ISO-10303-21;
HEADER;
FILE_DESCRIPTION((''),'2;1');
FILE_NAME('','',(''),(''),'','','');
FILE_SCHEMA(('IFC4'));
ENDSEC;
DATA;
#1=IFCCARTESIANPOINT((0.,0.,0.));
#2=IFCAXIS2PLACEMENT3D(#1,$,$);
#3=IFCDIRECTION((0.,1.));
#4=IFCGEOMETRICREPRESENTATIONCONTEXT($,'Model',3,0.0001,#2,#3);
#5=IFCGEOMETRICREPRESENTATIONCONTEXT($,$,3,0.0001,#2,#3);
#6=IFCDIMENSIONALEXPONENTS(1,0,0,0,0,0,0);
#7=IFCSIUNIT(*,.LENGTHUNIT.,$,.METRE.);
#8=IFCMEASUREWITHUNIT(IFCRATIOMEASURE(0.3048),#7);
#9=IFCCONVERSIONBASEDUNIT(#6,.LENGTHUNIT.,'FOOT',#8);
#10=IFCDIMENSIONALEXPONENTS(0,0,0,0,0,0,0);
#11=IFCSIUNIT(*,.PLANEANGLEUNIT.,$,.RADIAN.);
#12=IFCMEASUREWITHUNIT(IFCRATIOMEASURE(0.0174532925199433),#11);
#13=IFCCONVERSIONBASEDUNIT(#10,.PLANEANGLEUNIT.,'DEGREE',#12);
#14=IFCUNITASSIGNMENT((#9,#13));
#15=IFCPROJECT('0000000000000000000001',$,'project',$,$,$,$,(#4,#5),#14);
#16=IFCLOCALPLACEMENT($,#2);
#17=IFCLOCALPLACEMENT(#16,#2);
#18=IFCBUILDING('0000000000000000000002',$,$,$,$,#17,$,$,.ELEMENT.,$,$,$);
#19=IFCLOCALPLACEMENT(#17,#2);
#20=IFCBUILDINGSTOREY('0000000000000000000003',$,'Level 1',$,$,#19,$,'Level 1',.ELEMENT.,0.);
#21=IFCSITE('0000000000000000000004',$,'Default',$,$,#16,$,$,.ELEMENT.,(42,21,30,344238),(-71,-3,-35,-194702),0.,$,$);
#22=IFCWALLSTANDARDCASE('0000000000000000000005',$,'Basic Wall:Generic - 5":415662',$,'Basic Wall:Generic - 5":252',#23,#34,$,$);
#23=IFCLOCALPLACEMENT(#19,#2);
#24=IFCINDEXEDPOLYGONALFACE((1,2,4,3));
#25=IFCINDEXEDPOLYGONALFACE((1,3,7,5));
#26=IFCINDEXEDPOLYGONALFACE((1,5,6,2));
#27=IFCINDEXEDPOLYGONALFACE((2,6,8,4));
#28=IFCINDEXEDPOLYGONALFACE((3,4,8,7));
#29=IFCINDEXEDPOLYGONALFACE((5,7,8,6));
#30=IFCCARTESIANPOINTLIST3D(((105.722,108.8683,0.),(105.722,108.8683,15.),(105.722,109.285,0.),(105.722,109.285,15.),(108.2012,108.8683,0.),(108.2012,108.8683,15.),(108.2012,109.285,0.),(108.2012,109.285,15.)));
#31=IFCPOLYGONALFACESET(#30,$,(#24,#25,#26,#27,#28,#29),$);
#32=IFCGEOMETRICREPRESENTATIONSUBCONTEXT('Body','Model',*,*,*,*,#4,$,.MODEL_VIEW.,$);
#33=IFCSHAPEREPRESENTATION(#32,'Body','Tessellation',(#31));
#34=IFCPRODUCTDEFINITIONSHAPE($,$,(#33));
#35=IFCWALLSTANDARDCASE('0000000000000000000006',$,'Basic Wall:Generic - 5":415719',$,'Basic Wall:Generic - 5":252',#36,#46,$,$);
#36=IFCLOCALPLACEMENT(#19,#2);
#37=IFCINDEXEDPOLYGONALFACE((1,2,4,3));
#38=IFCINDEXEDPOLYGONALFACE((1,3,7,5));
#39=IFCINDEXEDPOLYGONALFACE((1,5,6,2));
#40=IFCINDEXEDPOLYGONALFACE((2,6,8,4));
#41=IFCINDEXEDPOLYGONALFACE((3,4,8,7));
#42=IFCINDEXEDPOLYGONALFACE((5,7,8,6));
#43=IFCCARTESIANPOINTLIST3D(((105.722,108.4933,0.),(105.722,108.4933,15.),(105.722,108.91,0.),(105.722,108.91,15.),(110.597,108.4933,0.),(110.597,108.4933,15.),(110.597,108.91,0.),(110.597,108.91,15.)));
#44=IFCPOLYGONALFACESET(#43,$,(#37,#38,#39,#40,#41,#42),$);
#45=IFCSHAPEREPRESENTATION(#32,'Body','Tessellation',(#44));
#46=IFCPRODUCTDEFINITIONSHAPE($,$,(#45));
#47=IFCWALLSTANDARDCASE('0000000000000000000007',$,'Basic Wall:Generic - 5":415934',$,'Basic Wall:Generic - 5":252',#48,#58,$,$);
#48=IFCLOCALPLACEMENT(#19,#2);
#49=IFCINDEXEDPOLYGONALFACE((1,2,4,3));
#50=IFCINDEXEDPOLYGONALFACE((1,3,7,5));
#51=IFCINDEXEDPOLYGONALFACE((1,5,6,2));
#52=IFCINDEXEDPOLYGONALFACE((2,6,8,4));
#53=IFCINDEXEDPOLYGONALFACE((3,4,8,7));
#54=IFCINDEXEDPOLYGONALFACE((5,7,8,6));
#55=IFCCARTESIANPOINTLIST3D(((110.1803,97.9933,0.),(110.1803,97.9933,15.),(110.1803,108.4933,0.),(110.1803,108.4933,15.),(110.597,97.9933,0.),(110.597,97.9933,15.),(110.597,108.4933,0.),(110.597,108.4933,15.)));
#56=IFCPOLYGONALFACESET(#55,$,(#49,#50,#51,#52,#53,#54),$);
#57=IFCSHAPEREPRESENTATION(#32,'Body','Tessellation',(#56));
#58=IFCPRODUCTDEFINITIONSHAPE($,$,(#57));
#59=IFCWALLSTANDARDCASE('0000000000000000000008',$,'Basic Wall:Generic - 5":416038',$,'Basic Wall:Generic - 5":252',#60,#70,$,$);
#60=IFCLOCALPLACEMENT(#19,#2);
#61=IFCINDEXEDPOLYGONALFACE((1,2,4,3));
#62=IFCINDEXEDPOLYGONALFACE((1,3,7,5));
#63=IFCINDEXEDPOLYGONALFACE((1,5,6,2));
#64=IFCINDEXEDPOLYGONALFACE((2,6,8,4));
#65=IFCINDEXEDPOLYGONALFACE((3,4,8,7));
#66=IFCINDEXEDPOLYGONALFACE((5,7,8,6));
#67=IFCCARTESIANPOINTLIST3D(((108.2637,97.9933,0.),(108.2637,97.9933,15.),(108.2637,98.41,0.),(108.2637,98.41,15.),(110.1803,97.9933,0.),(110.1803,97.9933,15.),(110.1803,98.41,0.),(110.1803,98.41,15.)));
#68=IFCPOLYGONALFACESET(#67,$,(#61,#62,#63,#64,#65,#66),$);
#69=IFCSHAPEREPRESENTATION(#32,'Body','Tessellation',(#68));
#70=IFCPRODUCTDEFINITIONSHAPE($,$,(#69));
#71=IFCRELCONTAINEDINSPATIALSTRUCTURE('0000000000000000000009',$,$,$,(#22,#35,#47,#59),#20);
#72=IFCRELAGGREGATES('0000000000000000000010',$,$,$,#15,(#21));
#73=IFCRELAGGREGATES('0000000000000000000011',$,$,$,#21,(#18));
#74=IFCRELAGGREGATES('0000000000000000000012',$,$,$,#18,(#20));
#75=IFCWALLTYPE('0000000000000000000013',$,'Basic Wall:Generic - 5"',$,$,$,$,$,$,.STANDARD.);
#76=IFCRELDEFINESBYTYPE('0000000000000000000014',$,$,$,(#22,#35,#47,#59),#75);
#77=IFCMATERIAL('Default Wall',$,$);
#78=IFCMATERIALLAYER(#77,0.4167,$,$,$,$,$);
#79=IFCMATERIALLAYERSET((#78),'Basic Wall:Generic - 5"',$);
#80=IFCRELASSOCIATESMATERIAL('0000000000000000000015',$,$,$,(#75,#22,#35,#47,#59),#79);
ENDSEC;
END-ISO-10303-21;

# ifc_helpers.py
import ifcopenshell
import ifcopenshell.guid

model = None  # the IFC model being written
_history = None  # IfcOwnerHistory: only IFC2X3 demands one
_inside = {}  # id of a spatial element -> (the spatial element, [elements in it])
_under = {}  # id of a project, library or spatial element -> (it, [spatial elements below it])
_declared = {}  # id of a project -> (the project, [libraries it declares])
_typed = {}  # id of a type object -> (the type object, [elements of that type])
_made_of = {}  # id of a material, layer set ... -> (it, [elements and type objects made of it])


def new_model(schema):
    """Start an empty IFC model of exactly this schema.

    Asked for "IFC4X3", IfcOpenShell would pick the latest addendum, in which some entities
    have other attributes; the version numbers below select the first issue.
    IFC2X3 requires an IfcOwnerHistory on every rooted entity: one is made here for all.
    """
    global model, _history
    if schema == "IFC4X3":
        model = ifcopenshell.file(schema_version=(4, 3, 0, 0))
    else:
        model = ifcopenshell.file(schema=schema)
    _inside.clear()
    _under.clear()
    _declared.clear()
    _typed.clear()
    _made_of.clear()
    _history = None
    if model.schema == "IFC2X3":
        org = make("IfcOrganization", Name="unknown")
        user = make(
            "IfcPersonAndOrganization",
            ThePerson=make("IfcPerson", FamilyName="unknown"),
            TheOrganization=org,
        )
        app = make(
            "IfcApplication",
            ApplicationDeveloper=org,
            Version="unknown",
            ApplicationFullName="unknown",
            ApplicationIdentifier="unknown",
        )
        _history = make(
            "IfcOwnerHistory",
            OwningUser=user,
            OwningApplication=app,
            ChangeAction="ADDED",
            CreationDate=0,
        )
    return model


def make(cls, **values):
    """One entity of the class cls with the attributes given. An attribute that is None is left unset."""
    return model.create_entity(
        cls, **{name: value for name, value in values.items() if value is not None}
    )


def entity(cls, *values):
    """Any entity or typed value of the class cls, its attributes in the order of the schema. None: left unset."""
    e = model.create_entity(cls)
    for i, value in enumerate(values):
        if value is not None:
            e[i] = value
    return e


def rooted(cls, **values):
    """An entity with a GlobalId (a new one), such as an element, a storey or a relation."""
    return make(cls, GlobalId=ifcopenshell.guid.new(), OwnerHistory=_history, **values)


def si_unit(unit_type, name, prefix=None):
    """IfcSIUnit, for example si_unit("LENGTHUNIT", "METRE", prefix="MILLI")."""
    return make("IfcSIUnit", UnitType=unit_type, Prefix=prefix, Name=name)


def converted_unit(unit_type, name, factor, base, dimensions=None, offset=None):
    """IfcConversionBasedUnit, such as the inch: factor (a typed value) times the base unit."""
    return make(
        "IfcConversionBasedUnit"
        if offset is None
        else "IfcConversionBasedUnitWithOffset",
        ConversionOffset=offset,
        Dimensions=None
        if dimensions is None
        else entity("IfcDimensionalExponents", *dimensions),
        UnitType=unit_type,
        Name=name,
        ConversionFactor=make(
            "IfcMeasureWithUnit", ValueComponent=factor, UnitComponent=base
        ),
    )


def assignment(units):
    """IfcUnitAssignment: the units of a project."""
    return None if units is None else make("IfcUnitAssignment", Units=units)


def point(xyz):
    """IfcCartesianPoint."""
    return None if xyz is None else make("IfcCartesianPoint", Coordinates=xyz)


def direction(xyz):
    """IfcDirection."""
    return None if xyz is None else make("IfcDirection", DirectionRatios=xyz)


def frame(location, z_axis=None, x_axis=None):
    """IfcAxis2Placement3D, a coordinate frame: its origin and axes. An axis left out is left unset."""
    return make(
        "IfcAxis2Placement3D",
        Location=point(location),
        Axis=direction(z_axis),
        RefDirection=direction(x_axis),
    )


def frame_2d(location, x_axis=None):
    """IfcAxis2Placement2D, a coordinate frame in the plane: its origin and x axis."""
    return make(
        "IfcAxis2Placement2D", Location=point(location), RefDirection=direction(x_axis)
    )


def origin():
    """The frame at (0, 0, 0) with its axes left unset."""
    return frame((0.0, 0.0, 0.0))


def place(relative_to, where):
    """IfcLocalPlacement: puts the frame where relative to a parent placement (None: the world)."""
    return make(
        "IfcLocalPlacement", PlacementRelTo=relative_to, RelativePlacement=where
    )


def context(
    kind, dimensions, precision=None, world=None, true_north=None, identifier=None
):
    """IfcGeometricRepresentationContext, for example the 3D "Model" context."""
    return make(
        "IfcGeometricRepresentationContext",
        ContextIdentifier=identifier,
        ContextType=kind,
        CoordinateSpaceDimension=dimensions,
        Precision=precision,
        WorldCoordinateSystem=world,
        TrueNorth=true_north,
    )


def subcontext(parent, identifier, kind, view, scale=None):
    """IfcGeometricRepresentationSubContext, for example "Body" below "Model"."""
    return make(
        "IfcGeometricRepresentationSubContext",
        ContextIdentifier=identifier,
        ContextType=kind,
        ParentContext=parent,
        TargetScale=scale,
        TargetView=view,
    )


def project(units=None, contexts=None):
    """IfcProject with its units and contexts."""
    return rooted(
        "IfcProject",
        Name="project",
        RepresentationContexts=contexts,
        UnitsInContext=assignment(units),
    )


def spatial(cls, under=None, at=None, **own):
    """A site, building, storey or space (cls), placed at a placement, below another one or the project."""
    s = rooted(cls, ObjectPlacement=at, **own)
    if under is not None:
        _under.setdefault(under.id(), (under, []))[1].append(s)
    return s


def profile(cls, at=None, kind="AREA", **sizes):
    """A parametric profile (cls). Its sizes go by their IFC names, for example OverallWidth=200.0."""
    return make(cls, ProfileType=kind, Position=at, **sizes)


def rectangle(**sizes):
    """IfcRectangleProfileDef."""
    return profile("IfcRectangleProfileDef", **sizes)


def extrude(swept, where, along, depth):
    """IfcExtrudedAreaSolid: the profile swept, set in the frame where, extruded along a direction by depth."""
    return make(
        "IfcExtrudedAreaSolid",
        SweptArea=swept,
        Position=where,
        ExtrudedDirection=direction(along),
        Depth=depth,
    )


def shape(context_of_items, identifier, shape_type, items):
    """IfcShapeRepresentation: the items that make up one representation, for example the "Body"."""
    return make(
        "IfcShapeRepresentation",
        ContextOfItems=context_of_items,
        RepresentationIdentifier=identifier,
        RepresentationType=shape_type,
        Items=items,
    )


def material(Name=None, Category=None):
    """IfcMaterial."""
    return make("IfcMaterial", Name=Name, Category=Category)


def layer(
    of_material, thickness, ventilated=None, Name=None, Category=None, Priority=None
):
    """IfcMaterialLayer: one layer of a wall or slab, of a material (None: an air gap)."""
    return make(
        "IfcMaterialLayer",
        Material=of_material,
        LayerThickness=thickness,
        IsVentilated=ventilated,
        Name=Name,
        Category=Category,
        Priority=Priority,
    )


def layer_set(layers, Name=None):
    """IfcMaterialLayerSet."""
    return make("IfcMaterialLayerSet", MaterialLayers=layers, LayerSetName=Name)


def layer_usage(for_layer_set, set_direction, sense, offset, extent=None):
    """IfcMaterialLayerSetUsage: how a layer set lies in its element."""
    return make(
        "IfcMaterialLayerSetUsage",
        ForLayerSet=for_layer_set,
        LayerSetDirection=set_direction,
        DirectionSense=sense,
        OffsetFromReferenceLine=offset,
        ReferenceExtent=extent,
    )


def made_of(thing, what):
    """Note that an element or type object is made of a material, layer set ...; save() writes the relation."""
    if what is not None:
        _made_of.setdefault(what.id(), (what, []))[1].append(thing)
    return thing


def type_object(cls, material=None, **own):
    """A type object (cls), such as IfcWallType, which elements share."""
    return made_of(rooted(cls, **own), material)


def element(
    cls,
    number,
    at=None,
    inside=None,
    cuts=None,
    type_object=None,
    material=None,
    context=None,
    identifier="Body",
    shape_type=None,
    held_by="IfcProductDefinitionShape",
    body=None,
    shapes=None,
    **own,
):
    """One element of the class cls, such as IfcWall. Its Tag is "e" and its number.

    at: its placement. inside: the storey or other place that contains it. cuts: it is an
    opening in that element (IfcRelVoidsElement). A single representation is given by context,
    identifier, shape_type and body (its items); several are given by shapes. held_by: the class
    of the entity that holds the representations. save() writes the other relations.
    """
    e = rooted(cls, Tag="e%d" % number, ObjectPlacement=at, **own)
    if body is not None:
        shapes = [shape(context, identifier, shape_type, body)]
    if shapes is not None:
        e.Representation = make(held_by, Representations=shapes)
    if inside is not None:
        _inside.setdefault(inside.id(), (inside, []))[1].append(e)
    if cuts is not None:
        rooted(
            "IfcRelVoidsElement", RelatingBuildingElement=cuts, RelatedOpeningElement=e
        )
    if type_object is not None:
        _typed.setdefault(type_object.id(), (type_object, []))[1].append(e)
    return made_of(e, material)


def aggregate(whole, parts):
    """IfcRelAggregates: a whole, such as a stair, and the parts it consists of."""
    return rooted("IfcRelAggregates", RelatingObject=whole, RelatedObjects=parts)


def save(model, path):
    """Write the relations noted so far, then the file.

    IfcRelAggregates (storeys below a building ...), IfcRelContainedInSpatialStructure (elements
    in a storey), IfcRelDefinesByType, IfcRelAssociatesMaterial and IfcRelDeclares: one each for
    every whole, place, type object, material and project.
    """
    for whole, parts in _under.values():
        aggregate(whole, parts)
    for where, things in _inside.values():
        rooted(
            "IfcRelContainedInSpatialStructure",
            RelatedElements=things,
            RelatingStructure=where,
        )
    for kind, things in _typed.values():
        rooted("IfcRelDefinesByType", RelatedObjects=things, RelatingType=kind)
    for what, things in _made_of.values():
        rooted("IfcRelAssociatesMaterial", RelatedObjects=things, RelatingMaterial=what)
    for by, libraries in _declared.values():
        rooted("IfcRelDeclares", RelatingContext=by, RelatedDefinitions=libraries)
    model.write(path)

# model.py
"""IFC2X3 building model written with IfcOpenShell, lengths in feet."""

from ifc_helpers import new_model, entity, si_unit, converted_unit, direction, frame, frame_2d, origin, place, context, subcontext, project, spatial, rectangle, extrude, material, layer, layer_set, layer_usage, type_object, element, save


model = new_model("IFC2X3")

# Units and contexts
model_context = context("Model", 3, precision=0.0001, world=origin(), true_north=direction((0.0, 1.0)))
context_of_model = context(None, 3, precision=0.0001, world=origin(), true_north=direction((0.0, 1.0)))
body_context = subcontext(model_context, "Body", "Model", "MODEL_VIEW")
ifc_project = project(units=[converted_unit("LENGTHUNIT", "FOOT", entity("IfcRatioMeasure", 0.3048), si_unit("LENGTHUNIT", "METRE"), dimensions=[1, 0, 0, 0, 0, 0, 0]), converted_unit("PLANEANGLEUNIT", "DEGREE", entity("IfcRatioMeasure", 0.0174532925199433), si_unit("PLANEANGLEUNIT", "RADIAN"), dimensions=[0, 0, 0, 0, 0, 0, 0])], contexts=[model_context, context_of_model])

# Site, building, storey
site_placement = place(None, origin())
site = spatial("IfcSite", under=ifc_project, at=site_placement, Name="Default", CompositionType="ELEMENT", RefLatitude=(42, 21, 30, 344238), RefLongitude=(-71, -3, -35, -194702), RefElevation=0.0)
building_placement = place(site_placement, origin())
building = spatial("IfcBuilding", under=site, at=building_placement, CompositionType="ELEMENT")
storey_placement = place(building_placement, origin())
storey = spatial("IfcBuildingStorey", under=building, at=storey_placement, Name="Level 1", LongName="Level 1", CompositionType="ELEMENT", Elevation=0.0)

# Shared definitions
ifc_material_1 = material(Name="Default Wall")

# Shared definitions
ifc_layer_1 = layer(ifc_material_1, 0.4167)
ifc_layer_set_1 = layer_set([ifc_layer_1], Name="Basic Wall:Generic - 5\"")
wall_type_1 = type_object("IfcWallType", Name="Basic Wall:Generic - 5\"", PredefinedType="STANDARD", material=ifc_layer_set_1)

# Walls
ifc_layer_usage_1 = layer_usage(ifc_layer_set_1, "AXIS2", "NEGATIVE", 0.2083)
wall_1_placement = place(storey_placement, frame((105.722, 109.0767, 0.0)))
element("IfcWallStandardCase", 1, at=wall_1_placement, inside=storey, type_object=wall_type_1, material=ifc_layer_usage_1, Name="Basic Wall:Generic - 5\":415662", ObjectType="Basic Wall:Generic - 5\":252", context=body_context, shape_type="SweptSolid", body=[
    extrude(rectangle(XDim=2.4792, YDim=0.4167, at=frame_2d((1.2396, 0.0), x_axis=(-1.0, 0.0))), origin(), (0.0, 0.0, 1.0), 15.0),
])
ifc_layer_usage_2 = layer_usage(ifc_layer_set_1, "AXIS2", "NEGATIVE", 0.2083)
wall_2_placement = place(storey_placement, frame((105.722, 108.7017, 0.0)))
element("IfcWallStandardCase", 2, at=wall_2_placement, inside=storey, type_object=wall_type_1, material=ifc_layer_usage_2, Name="Basic Wall:Generic - 5\":415719", ObjectType="Basic Wall:Generic - 5\":252", context=body_context, shape_type="SweptSolid", body=[
    extrude(rectangle(XDim=4.875, YDim=0.4167, at=frame_2d((2.4375, 0.0), x_axis=(-1.0, 0.0))), origin(), (0.0, 0.0, 1.0), 15.0),
])
ifc_layer_usage_3 = layer_usage(ifc_layer_set_1, "AXIS2", "NEGATIVE", 0.2083)
wall_3_placement = place(storey_placement, frame((110.3887, 108.4933, 0.0), z_axis=(0.0, 0.0, 1.0), x_axis=(0.0, -1.0, 0.0)))
element("IfcWallStandardCase", 3, at=wall_3_placement, inside=storey, type_object=wall_type_1, material=ifc_layer_usage_3, Name="Basic Wall:Generic - 5\":415934", ObjectType="Basic Wall:Generic - 5\":252", context=body_context, shape_type="SweptSolid", body=[
    extrude(rectangle(XDim=10.5, YDim=0.4167, at=frame_2d((5.25, 0.0), x_axis=(-1.0, 0.0))), origin(), (0.0, 0.0, 1.0), 15.0),
])
ifc_layer_usage_4 = layer_usage(ifc_layer_set_1, "AXIS2", "NEGATIVE", 0.2083)
wall_4_placement = place(storey_placement, frame((110.1803, 98.2017, 0.0), z_axis=(0.0, 0.0, 1.0), x_axis=(-1.0, 0.0, 0.0)))
element("IfcWallStandardCase", 4, at=wall_4_placement, inside=storey, type_object=wall_type_1, material=ifc_layer_usage_4, Name="Basic Wall:Generic - 5\":416038", ObjectType="Basic Wall:Generic - 5\":252", context=body_context, shape_type="SweptSolid", body=[
    extrude(rectangle(XDim=1.9167, YDim=0.4167, at=frame_2d((0.9583, 0.0), x_axis=(-1.0, 0.0))), origin(), (0.0, 0.0, 1.0), 15.0),
])

save(model, "model.ifc")
